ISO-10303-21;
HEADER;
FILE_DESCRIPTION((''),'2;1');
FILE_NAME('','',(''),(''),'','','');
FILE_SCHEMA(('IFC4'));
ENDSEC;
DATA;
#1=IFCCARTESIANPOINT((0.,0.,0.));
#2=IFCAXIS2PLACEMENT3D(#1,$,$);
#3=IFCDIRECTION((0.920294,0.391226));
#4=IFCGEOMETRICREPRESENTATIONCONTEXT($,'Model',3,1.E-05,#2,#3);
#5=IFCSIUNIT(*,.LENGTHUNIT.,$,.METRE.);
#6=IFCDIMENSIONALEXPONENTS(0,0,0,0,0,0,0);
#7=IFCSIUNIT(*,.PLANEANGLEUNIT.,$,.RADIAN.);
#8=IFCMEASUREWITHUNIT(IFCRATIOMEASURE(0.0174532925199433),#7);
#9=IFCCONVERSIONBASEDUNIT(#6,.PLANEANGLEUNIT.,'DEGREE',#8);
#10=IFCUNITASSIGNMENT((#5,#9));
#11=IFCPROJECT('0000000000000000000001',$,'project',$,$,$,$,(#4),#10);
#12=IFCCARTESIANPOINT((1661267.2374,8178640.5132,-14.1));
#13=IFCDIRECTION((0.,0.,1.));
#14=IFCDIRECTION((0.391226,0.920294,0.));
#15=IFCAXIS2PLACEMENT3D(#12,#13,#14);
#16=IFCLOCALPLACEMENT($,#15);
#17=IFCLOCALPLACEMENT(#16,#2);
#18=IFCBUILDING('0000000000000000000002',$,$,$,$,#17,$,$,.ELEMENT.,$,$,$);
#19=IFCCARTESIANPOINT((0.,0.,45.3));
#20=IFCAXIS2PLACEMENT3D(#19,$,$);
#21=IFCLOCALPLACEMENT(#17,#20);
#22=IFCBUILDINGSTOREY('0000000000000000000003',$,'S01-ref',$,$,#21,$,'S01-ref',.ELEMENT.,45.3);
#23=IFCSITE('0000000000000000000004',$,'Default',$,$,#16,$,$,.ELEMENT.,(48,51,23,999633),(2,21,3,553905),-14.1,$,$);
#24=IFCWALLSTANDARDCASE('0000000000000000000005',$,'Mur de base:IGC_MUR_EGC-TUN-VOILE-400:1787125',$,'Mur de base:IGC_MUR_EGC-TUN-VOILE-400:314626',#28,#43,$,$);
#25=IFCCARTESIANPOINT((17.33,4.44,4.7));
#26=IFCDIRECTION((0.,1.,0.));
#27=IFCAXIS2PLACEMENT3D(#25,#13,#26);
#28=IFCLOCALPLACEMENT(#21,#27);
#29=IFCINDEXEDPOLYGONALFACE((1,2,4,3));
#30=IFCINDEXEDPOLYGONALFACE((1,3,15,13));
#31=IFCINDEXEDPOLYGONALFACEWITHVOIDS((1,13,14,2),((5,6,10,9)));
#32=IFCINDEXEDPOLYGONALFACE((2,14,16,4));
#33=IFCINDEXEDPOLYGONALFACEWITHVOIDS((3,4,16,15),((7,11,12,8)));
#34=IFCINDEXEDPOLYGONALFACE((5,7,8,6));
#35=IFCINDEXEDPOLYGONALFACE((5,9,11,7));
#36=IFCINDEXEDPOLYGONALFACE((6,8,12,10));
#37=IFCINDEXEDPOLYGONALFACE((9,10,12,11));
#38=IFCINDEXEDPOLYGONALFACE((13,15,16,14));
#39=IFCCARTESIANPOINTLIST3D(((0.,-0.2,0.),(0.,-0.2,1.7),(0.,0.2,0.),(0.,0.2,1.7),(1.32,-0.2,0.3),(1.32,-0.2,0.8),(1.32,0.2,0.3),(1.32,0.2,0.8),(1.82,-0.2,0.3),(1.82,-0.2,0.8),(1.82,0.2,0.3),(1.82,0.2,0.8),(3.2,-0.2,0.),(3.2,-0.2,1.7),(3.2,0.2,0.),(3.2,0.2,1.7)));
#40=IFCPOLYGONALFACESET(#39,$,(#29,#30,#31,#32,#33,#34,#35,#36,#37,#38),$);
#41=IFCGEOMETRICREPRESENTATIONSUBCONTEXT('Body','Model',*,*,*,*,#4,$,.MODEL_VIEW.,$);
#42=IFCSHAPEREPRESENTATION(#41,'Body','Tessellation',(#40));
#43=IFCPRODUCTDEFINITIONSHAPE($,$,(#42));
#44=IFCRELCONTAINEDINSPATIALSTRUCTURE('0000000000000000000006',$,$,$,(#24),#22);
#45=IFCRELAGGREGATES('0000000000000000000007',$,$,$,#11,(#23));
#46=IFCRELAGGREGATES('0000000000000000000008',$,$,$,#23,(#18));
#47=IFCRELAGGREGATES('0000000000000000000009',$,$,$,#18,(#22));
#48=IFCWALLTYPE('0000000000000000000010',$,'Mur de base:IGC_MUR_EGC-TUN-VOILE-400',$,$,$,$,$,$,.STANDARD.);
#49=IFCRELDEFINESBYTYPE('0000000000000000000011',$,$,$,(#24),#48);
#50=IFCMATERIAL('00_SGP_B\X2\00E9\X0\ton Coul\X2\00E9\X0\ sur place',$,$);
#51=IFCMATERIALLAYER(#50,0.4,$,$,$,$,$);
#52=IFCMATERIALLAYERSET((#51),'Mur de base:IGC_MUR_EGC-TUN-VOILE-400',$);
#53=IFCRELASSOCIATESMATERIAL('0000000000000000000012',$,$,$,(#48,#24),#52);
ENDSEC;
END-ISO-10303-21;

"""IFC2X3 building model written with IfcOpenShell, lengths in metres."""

from ifc_helpers import new_model, entity, si_unit, converted_unit, direction, frame, frame_2d, origin, place, context, subcontext, project, spatial, rectangle, extrude, material, layer, layer_set, layer_usage, type_object, element, save


model = new_model("IFC2X3")

# Units and contexts
model_context = context("Model", 3, precision=1e-05, world=origin(), true_north=direction((0.920294, 0.391226)))
body_context = subcontext(model_context, "Body", "Model", "MODEL_VIEW")
ifc_project = project(units=[si_unit("LENGTHUNIT", "METRE"), converted_unit("PLANEANGLEUNIT", "DEGREE", entity("IfcRatioMeasure", 0.0174532925199433), si_unit("PLANEANGLEUNIT", "RADIAN"), dimensions=[0, 0, 0, 0, 0, 0, 0])], contexts=[model_context])

# Site, building, storey
site_placement = place(None, frame((1661267.2374, 8178640.5132, -14.1), z_axis=(0.0, 0.0, 1.0), x_axis=(0.391226, 0.920294, 0.0)))
site = spatial("IfcSite", under=ifc_project, at=site_placement, Name="Default", CompositionType="ELEMENT", RefLatitude=(48, 51, 23, 999633), RefLongitude=(2, 21, 3, 553905), RefElevation=-14.1)
building_placement = place(site_placement, origin())
building = spatial("IfcBuilding", under=site, at=building_placement, CompositionType="ELEMENT")
storey_placement = place(building_placement, frame((0.0, 0.0, 45.3)))
storey = spatial("IfcBuildingStorey", under=building, at=storey_placement, Name="S01-ref", LongName="S01-ref", CompositionType="ELEMENT", Elevation=45.3)

# Shared definitions
ifc_material = material(Name="00_SGP_Béton Coulé sur place")
ifc_layer_1 = layer(ifc_material, 0.4)
ifc_layer_set_1 = layer_set([ifc_layer_1], Name="Mur de base:IGC_MUR_EGC-TUN-VOILE-400")
wall_type_1 = type_object("IfcWallType", Name="Mur de base:IGC_MUR_EGC-TUN-VOILE-400", PredefinedType="STANDARD", material=ifc_layer_set_1)

# Wall, opening
ifc_layer_usage_1 = layer_usage(ifc_layer_set_1, "AXIS2", "NEGATIVE", 0.2)
wall_1_placement = place(storey_placement, frame((17.33, 4.44, 4.7), z_axis=(0.0, 0.0, 1.0), x_axis=(0.0, 1.0, 0.0)))
wall_1 = element("IfcWallStandardCase", 1, at=wall_1_placement, inside=storey, type_object=wall_type_1, material=ifc_layer_usage_1, Name="Mur de base:IGC_MUR_EGC-TUN-VOILE-400:1787125", ObjectType="Mur de base:IGC_MUR_EGC-TUN-VOILE-400:314626", context=body_context, shape_type="SweptSolid", body=[
    extrude(rectangle(XDim=3.2, YDim=0.4, at=frame_2d((1.6, 0.0), x_axis=(-1.0, 0.0))), origin(), (0.0, 0.0, 1.0), 1.7),
])
opening_1_placement = place(wall_1_placement, origin())
element("IfcOpeningElement", 2, at=opening_1_placement, cuts=wall_1, ObjectType="Opening", context=body_context, shape_type="SweptSolid", body=[
    extrude(rectangle(XDim=0.5, YDim=0.5, at=frame_2d((0.0, 0.0), x_axis=(1.0, 0.0))), frame((1.57, -1.324, 0.55), z_axis=(0.0, 1.0, 0.0), x_axis=(0.0, 0.0, -1.0)), (0.0, 0.0, 1.0), 3.048),
])

save(model, "model.ifc")
